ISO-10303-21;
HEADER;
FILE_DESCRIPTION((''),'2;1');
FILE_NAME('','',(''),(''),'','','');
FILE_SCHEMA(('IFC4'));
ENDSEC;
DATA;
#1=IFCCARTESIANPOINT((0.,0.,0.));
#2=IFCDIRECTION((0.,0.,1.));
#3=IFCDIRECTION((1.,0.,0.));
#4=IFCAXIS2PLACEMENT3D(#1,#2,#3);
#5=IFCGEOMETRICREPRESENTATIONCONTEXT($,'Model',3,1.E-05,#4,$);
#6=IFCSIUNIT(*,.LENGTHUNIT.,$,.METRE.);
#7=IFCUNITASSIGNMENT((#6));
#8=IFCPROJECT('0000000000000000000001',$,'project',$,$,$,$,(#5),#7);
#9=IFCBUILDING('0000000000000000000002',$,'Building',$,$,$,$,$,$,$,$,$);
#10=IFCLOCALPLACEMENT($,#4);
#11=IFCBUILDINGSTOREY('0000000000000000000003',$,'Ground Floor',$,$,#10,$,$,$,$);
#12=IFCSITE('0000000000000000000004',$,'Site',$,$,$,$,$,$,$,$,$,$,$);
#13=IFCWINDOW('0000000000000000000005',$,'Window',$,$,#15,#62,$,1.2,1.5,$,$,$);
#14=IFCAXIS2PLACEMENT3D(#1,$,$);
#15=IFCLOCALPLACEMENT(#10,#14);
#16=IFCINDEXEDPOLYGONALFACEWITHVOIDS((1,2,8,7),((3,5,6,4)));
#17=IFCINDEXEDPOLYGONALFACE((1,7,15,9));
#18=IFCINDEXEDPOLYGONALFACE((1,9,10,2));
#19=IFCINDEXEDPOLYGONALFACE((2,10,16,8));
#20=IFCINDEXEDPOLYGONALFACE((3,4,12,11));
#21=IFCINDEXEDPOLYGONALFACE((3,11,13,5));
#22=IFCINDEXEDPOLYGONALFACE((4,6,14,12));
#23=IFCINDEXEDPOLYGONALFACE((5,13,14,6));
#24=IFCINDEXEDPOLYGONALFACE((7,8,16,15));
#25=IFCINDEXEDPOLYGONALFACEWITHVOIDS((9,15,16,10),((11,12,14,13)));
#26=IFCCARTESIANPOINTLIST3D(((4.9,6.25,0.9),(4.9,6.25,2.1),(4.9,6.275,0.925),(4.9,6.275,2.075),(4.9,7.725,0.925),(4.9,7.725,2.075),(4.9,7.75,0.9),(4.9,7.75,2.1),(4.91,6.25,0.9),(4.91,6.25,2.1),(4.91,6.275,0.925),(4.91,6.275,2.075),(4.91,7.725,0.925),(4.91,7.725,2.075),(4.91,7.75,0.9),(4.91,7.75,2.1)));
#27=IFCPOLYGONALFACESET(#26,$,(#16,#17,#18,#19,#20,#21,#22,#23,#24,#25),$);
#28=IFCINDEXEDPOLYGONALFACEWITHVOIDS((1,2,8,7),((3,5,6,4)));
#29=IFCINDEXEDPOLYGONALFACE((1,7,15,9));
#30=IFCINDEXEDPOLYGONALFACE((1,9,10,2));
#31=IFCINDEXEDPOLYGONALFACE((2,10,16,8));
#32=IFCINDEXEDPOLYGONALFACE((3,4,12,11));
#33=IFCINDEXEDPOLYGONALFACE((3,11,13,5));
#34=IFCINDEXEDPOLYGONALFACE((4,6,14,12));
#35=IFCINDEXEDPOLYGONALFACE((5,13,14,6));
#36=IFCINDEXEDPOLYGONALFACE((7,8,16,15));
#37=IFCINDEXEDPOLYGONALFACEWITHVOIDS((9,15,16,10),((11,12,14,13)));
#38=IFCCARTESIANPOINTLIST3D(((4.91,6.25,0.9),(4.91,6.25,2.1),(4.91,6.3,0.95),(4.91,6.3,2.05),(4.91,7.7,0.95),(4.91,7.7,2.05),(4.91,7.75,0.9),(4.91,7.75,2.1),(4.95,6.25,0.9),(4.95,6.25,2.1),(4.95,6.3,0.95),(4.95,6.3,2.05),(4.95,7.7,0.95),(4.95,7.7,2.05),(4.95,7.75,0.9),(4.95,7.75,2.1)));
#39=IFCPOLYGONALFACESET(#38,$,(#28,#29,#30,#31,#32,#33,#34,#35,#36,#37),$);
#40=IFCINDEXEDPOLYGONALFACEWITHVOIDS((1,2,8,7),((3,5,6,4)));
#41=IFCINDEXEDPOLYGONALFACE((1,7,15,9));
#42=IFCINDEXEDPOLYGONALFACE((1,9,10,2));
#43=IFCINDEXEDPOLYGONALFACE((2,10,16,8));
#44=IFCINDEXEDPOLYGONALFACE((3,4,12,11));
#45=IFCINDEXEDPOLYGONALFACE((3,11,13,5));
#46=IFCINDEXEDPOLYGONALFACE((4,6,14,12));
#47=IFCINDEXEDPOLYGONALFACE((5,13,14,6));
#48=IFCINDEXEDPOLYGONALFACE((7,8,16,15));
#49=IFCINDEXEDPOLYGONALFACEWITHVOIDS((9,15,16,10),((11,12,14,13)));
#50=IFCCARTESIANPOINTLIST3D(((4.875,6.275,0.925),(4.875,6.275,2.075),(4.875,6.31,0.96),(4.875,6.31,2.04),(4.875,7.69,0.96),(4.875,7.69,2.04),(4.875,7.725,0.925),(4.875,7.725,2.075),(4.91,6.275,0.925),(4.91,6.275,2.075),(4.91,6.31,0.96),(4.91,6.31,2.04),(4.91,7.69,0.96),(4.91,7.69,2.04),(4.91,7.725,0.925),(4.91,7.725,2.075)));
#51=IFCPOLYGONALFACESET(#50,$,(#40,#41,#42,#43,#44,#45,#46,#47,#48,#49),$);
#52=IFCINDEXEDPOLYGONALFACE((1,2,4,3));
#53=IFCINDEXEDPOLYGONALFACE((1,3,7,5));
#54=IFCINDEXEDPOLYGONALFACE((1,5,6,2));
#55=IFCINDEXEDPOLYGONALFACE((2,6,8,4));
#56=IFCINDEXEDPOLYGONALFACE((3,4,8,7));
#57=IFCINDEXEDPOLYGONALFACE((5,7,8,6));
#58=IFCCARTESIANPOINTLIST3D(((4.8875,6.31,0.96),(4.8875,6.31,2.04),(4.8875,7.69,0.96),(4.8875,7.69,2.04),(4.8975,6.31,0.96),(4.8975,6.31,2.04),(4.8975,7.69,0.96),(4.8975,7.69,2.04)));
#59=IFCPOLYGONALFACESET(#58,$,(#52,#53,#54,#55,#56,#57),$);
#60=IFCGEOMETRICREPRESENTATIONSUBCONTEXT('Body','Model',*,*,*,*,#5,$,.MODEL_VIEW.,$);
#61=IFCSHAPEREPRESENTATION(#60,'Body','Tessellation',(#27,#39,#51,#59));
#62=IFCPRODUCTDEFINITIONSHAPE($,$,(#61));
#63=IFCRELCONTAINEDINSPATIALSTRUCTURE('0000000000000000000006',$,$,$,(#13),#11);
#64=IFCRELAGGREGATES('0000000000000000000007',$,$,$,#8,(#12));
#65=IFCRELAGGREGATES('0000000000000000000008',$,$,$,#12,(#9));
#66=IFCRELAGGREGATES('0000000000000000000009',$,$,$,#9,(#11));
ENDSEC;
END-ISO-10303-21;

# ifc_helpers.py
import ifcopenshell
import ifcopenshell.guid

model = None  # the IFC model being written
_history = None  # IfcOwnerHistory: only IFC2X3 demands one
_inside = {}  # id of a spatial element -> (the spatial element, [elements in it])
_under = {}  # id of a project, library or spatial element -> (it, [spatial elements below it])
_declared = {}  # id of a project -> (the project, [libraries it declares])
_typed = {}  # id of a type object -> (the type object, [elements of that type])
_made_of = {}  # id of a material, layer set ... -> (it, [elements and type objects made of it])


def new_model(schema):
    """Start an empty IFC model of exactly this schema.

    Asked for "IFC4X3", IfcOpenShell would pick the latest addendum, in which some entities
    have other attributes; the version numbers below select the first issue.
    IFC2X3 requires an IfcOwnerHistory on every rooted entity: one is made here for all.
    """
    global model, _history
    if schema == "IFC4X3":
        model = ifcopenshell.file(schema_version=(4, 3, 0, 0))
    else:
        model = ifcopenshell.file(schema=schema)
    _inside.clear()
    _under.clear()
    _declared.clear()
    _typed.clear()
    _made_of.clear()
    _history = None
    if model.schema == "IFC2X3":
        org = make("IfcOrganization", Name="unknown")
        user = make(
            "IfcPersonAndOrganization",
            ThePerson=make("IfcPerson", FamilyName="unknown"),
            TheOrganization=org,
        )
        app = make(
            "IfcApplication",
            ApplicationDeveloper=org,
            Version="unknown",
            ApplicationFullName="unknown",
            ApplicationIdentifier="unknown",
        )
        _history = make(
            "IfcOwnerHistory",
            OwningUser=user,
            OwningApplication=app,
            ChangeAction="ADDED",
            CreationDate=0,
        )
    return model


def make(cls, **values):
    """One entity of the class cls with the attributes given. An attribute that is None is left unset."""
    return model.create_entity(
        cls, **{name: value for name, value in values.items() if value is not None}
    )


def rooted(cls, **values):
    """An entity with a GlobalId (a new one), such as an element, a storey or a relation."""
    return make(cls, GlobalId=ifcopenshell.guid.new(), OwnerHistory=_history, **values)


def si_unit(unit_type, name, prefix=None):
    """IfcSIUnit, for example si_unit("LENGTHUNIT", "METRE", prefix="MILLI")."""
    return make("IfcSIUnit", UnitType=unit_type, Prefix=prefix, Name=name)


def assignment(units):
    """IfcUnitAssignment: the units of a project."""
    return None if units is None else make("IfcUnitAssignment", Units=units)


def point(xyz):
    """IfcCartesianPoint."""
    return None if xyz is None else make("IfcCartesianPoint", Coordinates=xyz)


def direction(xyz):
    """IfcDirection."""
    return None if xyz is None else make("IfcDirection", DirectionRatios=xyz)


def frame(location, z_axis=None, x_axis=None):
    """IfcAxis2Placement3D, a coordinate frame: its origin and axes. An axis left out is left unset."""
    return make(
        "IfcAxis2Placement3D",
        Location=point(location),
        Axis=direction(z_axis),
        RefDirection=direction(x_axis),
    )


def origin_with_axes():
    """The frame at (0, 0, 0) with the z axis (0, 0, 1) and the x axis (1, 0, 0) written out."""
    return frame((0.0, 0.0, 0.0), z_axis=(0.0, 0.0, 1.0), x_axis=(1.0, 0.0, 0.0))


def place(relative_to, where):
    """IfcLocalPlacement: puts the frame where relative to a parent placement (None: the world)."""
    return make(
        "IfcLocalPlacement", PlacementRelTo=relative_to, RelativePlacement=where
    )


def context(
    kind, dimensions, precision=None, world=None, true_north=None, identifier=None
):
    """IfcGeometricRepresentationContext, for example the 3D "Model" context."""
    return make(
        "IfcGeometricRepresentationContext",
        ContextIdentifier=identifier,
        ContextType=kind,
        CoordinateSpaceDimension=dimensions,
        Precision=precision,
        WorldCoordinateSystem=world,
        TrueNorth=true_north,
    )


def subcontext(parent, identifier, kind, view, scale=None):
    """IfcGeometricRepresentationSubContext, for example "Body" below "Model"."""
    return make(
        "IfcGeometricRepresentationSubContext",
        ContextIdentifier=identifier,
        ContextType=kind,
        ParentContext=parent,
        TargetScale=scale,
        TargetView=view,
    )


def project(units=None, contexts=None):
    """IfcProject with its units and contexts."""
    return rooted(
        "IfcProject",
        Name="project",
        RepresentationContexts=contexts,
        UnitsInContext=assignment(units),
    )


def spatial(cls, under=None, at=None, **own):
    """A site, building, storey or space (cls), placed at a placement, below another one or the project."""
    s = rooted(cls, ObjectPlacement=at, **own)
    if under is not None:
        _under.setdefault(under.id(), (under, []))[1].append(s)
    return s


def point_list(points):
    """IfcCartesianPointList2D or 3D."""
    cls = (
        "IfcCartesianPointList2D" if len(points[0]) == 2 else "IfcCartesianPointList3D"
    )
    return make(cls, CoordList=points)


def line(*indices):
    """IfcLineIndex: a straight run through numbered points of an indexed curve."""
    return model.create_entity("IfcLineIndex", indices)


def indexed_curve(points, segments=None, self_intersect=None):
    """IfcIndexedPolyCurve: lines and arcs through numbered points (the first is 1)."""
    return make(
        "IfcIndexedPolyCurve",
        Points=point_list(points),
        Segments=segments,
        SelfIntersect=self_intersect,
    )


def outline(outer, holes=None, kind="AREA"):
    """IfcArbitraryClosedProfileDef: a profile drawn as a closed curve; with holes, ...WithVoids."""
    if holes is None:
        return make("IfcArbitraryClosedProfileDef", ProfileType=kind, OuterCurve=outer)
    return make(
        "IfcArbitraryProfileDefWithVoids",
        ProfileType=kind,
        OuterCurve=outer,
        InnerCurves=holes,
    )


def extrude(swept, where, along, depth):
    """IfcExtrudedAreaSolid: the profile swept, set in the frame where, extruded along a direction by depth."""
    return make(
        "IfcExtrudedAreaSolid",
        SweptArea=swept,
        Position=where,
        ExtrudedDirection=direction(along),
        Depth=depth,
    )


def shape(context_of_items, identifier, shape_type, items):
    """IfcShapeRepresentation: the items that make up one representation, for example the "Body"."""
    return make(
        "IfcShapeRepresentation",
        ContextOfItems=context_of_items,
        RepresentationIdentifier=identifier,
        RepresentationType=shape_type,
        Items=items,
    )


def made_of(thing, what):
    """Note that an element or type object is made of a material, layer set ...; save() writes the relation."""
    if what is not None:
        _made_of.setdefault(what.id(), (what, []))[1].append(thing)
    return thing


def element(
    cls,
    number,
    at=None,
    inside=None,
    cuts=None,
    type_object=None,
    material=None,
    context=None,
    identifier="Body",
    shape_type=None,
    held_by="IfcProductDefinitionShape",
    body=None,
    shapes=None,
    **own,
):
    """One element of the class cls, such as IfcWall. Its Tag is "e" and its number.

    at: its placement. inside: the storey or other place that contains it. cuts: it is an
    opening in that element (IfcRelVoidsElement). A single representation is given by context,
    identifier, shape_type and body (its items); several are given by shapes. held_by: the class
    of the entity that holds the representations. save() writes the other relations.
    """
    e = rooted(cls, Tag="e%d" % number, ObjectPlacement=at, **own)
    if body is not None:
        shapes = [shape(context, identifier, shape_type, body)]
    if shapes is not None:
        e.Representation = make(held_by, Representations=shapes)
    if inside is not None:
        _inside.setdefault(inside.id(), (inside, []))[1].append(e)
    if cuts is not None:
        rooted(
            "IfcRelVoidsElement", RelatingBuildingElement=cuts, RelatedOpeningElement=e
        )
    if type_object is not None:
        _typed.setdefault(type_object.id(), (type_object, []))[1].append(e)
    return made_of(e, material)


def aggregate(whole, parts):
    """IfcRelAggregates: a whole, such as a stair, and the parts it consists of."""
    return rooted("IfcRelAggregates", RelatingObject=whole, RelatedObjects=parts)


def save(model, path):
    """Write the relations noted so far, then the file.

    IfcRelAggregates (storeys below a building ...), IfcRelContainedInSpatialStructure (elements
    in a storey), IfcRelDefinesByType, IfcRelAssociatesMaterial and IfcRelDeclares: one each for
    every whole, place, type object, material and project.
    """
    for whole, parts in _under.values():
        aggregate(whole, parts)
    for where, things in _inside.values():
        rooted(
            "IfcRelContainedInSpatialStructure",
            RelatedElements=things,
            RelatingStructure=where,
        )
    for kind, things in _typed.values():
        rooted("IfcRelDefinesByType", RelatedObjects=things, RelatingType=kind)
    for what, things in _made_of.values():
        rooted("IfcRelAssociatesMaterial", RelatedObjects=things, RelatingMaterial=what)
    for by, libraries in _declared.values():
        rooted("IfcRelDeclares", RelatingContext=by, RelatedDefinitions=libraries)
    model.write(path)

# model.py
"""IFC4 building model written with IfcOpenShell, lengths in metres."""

from ifc_helpers import new_model, si_unit, frame, origin_with_axes, place, context, subcontext, project, spatial, line, indexed_curve, outline, extrude, element, save


model = new_model("IFC4")

# Units and contexts
model_context = context("Model", 3, precision=1e-05, world=origin_with_axes())
body_context = subcontext(model_context, "Body", "Model", "MODEL_VIEW")
ifc_project = project(units=[si_unit("LENGTHUNIT", "METRE")], contexts=[model_context])

# Site, building, storey
site = spatial("IfcSite", under=ifc_project, Name="Site")
building = spatial("IfcBuilding", under=site, Name="Building")
storey_placement = place(None, origin_with_axes())
storey = spatial("IfcBuildingStorey", under=building, at=storey_placement, Name="Ground Floor")

# Window
for number, where, z_axis, x_axis, name in (
    (1, (5.0, 6.25, 0.9), (0.0, 0.0, 1.0), (0.0, 1.0, 0.0), "Window"),
):
    element("IfcWindow", number, at=place(storey_placement, frame(where, z_axis=z_axis, x_axis=x_axis)), inside=storey, Name=name, OverallHeight=1.2, OverallWidth=1.5, context=body_context, shape_type="SweptSolid", body=[
        extrude(outline(indexed_curve([(0.0, 0.0), (1.5, 0.0), (1.5, 1.2), (0.0, 1.2)], segments=[line(1, 2, 3, 4, 1)]), holes=[indexed_curve([(0.025, 0.025), (1.475, 0.025), (1.475, 1.175), (0.025, 1.175)], segments=[line(1, 2, 3, 4, 1)])]), frame((0.0, 0.09, 0.0), z_axis=(0.0, -1.0, 0.0), x_axis=(1.0, 0.0, 0.0)), (0.0, 0.0, -1.0), 0.01),
        extrude(outline(indexed_curve([(0.0, 0.0), (1.5, 0.0), (1.5, 1.2), (0.0, 1.2)], segments=[line(1, 2, 3, 4, 1)]), holes=[indexed_curve([(0.05, 0.05), (1.45, 0.05), (1.45, 1.15), (0.05, 1.15)], segments=[line(1, 2, 3, 4, 1)])]), frame((0.0, 0.05, 0.0), z_axis=(0.0, -1.0, 0.0), x_axis=(1.0, 0.0, 0.0)), (0.0, 0.0, -1.0), 0.04),
        extrude(outline(indexed_curve([(0.0, 0.0), (1.45, 0.0), (1.45, 1.15), (0.0, 1.15)], segments=[line(1, 2, 3, 4, 1)]), holes=[indexed_curve([(0.035, 0.035), (1.415, 0.035), (1.415, 1.115), (0.035, 1.115)], segments=[line(1, 2, 3, 4, 1)])]), frame((0.025, 0.09, 0.025), z_axis=(0.0, -1.0, 0.0), x_axis=(1.0, 0.0, 0.0)), (0.0, 0.0, -1.0), 0.035),
        extrude(outline(indexed_curve([(0.035, 0.035), (1.415, 0.035), (1.415, 1.115), (0.035, 1.115)], segments=[line(1, 2, 3, 4, 1)])), frame((0.025, 0.1025, 0.025), z_axis=(0.0, -1.0, 0.0), x_axis=(1.0, 0.0, 0.0)), (0.0, 0.0, -1.0), 0.01),
    ])

save(model, "model.ifc")
